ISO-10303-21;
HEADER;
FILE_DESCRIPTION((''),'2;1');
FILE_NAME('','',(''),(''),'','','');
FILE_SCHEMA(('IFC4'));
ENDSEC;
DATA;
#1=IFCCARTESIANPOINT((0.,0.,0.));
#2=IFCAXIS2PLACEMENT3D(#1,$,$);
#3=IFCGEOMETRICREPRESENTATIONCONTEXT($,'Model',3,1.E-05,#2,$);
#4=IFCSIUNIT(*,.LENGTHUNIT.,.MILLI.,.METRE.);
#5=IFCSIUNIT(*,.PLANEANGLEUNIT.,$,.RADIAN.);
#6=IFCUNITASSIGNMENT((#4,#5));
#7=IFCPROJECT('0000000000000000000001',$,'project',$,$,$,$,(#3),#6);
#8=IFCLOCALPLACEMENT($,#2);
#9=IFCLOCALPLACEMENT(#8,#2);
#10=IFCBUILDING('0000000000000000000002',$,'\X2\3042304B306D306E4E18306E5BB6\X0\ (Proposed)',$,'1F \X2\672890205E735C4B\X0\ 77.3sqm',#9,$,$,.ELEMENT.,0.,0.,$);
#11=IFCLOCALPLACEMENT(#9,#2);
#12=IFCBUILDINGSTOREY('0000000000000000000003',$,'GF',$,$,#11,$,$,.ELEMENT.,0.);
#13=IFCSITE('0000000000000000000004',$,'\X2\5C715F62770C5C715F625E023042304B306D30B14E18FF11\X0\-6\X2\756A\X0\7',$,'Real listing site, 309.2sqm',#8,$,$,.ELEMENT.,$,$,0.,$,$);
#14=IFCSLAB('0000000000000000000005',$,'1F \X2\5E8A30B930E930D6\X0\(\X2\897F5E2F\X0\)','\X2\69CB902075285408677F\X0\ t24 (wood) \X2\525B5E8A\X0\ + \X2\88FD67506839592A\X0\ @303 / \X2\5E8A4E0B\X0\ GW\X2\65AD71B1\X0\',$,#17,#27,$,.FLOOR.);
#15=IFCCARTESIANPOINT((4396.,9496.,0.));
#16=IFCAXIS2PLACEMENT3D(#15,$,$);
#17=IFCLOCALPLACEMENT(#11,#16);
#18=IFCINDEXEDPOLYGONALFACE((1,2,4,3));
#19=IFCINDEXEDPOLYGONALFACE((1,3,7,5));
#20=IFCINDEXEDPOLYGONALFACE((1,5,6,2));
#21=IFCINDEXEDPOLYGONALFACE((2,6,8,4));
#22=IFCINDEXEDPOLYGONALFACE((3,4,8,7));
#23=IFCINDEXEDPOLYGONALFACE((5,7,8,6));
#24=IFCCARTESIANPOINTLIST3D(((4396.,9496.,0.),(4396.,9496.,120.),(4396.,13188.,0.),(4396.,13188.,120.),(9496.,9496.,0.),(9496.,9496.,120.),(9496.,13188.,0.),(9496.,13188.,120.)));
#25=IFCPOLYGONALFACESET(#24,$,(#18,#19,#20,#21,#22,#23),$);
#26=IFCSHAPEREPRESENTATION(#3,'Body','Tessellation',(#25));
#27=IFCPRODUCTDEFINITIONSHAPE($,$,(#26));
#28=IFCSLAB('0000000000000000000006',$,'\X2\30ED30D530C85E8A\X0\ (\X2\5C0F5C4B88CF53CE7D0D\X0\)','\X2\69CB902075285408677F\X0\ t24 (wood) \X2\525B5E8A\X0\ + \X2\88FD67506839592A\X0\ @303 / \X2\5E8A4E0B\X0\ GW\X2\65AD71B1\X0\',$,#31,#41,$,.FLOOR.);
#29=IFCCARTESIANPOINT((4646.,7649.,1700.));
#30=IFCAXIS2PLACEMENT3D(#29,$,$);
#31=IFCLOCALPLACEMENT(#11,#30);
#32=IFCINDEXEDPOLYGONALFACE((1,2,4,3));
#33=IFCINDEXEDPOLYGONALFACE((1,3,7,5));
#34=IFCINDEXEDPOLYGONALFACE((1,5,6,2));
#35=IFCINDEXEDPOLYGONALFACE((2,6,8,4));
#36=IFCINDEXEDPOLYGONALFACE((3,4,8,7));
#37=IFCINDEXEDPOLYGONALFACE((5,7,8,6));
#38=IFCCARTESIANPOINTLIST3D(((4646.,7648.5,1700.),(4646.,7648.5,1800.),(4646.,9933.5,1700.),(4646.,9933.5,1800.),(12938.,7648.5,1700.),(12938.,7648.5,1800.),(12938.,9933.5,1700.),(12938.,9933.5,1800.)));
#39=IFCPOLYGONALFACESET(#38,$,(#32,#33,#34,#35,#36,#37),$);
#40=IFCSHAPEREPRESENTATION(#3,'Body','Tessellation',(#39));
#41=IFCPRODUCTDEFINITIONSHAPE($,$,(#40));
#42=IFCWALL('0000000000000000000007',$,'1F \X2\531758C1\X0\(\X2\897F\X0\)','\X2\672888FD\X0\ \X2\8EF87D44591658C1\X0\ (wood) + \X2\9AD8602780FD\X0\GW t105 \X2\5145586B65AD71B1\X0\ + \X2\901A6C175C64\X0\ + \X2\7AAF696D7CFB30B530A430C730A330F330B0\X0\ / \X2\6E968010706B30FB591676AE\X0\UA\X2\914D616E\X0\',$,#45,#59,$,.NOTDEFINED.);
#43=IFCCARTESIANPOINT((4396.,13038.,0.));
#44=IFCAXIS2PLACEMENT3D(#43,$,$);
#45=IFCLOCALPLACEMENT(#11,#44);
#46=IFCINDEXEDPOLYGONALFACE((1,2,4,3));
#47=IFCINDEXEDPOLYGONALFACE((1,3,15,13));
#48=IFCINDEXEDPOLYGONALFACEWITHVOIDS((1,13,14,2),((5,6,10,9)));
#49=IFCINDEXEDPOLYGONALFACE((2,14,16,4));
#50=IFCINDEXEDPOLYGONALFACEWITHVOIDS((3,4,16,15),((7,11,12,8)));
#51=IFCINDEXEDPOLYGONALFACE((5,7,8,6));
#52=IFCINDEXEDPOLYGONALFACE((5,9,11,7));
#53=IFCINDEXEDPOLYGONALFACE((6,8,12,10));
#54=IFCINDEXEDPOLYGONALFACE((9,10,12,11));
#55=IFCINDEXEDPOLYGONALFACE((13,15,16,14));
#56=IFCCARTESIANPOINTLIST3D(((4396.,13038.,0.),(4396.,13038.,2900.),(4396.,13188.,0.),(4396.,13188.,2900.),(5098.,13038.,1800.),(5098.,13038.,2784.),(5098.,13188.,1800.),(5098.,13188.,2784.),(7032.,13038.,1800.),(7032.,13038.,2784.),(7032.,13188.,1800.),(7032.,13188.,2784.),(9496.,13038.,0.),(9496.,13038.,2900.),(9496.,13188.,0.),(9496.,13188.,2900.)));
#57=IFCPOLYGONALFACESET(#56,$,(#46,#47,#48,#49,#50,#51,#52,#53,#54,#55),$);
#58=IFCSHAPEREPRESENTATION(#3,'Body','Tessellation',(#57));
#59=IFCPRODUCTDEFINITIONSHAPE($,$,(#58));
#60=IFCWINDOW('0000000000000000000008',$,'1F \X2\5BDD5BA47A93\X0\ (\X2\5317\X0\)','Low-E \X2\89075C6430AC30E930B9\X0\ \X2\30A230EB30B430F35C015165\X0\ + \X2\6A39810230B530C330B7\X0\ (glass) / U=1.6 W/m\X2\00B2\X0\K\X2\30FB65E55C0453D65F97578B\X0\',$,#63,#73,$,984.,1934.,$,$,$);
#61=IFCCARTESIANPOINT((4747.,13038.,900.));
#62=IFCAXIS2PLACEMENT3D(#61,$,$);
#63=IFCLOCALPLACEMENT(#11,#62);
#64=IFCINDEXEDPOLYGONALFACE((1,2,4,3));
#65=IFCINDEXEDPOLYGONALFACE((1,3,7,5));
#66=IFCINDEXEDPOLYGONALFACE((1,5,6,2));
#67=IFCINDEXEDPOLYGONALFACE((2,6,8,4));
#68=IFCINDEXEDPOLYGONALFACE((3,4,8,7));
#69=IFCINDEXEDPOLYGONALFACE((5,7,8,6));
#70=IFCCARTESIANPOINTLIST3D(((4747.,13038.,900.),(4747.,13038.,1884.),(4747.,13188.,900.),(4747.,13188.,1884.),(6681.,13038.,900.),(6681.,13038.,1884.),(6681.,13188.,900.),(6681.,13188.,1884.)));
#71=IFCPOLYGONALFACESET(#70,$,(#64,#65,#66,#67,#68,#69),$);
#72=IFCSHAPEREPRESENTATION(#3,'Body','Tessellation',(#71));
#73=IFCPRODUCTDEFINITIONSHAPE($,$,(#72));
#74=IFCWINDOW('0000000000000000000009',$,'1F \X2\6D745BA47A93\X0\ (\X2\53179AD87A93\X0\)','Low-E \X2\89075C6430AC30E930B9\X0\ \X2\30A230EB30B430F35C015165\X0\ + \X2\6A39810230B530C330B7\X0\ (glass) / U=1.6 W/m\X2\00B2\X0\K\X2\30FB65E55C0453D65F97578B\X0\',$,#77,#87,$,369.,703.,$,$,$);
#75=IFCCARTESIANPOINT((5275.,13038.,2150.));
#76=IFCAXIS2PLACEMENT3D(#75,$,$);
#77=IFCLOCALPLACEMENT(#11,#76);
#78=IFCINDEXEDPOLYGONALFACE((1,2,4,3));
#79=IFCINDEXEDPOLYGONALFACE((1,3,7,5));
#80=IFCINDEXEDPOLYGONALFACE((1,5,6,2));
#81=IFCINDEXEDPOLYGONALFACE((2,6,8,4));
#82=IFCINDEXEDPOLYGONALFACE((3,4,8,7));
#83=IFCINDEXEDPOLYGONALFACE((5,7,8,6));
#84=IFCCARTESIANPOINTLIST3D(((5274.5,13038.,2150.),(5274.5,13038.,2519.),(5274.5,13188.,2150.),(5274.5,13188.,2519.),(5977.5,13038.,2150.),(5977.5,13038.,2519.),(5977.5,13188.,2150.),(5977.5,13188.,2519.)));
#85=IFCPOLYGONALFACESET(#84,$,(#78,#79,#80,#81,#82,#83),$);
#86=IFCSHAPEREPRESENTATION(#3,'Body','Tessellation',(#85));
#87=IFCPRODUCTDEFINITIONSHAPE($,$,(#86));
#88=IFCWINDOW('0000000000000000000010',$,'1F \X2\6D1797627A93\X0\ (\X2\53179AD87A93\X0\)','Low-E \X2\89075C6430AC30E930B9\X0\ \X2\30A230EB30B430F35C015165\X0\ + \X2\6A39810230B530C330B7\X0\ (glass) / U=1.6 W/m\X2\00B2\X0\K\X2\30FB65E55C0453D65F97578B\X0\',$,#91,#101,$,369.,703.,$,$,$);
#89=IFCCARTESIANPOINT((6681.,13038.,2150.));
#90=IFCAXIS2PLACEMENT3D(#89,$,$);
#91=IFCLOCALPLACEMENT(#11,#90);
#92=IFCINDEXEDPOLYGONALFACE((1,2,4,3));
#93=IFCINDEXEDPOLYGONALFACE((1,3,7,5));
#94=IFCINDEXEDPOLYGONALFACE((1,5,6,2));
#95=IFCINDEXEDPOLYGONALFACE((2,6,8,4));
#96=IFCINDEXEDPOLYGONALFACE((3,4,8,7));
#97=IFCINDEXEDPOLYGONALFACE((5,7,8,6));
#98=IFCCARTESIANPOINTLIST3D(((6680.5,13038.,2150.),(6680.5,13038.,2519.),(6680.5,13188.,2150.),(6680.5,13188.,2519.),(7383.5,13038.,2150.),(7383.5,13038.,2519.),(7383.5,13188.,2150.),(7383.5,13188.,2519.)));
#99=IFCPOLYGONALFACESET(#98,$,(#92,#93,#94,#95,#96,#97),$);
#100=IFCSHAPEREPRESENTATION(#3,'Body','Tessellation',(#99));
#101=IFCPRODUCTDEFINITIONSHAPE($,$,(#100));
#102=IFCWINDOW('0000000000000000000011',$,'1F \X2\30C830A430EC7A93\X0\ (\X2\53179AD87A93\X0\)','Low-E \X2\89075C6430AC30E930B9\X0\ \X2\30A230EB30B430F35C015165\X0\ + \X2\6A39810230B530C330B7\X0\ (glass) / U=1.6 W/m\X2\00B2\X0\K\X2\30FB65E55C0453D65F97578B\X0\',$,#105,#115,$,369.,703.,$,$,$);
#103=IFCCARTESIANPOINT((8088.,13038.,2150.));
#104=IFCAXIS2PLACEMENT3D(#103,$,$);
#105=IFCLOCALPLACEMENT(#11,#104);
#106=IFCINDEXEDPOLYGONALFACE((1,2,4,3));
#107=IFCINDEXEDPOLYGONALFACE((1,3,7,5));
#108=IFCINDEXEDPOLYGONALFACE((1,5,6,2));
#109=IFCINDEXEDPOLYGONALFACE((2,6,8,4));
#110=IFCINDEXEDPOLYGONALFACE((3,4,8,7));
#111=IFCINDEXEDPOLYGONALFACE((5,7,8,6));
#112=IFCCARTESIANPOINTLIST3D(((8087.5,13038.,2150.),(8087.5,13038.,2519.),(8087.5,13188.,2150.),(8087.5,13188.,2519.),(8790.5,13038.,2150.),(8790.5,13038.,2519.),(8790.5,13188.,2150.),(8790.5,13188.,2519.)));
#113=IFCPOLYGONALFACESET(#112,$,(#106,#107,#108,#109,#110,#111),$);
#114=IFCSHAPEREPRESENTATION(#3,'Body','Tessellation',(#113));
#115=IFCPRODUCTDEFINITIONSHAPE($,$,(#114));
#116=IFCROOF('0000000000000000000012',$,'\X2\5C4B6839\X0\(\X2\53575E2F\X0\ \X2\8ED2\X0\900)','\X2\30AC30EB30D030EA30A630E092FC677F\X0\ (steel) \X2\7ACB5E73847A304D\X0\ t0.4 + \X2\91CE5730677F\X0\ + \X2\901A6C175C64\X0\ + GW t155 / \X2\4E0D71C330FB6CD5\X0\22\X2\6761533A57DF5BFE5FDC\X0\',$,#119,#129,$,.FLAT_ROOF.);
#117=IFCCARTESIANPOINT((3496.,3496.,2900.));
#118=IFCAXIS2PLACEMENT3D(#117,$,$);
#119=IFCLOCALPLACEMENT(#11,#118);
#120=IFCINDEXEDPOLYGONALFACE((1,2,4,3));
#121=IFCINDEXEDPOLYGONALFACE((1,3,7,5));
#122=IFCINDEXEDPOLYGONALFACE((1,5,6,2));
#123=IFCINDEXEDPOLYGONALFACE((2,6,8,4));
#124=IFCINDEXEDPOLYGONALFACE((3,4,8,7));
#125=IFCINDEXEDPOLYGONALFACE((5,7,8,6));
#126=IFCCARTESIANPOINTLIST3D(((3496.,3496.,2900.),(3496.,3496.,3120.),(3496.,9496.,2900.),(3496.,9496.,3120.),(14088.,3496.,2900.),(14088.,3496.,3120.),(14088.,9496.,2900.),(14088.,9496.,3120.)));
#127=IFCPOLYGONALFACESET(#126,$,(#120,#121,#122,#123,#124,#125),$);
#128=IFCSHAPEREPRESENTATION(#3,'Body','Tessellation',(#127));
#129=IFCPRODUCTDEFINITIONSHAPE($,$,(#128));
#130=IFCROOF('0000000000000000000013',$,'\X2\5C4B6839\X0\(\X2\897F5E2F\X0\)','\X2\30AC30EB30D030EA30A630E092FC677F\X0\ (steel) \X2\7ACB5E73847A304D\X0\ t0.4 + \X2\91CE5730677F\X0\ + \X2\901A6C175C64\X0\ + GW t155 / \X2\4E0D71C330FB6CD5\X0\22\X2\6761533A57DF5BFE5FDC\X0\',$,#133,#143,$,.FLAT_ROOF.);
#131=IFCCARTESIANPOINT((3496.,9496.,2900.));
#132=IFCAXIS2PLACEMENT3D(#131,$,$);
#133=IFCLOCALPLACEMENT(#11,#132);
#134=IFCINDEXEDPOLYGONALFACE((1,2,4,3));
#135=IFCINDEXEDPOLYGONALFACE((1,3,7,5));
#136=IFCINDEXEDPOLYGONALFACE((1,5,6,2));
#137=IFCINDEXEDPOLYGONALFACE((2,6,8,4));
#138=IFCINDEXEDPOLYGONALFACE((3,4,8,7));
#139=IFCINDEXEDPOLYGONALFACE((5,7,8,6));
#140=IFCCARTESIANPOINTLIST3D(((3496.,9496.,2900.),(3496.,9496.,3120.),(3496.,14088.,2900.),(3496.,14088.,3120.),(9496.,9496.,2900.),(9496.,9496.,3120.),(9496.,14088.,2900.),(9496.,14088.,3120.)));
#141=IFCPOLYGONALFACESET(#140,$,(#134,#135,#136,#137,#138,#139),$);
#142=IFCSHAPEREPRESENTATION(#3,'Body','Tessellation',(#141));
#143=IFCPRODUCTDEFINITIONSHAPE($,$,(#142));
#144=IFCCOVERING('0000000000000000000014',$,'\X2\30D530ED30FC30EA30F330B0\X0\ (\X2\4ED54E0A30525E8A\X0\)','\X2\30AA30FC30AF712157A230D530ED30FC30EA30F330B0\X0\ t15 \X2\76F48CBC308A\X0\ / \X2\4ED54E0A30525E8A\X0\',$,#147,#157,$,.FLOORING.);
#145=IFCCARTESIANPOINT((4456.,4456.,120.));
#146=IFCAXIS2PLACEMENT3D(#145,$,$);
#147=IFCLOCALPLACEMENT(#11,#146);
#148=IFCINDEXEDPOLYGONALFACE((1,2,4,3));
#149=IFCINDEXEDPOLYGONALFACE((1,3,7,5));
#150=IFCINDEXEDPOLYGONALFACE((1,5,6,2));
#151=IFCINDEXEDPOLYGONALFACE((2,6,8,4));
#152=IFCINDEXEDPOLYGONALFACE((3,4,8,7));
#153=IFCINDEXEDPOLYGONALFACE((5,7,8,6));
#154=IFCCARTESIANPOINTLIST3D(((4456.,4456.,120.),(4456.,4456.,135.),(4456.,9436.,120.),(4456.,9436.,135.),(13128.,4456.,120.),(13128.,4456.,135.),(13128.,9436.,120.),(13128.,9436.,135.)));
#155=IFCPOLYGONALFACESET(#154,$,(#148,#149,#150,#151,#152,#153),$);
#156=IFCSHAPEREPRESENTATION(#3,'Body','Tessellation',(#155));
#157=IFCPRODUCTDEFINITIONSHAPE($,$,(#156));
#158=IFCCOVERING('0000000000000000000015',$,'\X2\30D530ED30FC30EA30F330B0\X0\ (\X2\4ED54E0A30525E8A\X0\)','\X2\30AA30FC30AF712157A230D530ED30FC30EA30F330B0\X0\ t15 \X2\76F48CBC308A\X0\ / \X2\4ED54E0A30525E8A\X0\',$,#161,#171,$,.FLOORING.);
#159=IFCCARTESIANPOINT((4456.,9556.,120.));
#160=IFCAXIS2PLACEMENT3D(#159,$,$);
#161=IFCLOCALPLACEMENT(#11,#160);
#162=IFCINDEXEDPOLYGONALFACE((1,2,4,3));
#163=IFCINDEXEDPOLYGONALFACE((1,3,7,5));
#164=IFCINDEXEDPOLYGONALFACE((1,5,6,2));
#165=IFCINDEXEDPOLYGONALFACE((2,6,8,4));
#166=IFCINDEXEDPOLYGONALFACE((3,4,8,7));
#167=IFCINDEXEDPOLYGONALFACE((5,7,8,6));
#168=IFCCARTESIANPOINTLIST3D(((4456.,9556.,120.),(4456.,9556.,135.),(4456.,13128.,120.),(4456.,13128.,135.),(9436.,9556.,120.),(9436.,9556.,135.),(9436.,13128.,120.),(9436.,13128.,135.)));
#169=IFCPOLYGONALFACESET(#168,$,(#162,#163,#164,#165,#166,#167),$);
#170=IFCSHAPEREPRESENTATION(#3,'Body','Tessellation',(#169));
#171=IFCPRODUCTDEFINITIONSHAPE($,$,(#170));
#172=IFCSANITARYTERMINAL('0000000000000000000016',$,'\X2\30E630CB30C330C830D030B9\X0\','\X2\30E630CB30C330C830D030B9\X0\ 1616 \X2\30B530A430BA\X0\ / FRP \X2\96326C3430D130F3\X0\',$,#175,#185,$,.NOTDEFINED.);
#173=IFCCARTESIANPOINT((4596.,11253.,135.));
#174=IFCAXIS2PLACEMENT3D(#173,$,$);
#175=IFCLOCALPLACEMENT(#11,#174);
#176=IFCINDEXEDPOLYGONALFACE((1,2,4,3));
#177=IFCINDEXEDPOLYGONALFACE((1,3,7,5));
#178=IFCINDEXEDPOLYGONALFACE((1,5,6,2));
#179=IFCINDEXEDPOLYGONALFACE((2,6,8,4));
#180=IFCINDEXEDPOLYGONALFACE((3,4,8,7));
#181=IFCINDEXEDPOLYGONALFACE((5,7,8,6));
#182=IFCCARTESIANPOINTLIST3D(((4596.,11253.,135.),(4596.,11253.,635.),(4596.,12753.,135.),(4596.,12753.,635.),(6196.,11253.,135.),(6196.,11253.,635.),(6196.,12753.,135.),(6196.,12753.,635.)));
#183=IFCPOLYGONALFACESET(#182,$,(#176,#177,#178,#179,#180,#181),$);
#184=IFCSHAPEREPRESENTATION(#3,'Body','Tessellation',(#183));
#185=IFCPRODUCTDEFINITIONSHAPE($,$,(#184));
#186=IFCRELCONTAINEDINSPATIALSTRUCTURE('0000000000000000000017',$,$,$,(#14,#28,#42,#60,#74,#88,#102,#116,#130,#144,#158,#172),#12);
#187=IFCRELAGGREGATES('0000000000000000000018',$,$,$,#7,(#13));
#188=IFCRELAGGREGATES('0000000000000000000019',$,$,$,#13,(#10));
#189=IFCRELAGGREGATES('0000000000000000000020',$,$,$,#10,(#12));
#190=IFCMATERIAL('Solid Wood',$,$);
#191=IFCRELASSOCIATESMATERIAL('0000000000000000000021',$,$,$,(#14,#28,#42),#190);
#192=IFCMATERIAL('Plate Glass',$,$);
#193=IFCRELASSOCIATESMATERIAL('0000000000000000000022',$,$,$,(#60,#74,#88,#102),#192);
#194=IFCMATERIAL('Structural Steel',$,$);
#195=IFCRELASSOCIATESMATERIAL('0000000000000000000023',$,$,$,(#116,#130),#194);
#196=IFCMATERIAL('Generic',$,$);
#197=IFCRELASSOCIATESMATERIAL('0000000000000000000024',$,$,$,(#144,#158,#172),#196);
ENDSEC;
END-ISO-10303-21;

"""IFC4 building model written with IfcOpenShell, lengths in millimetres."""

from ifc_helpers import new_model, si_unit, frame, frame_2d, origin, place, context, project, spatial, rectangle, extrude, material, element, fill, save


model = new_model("IFC4")

# Units and contexts
model_context = context("Model", 3, precision=1e-05, world=origin())
ifc_project = project(units=[si_unit("LENGTHUNIT", "METRE", prefix="MILLI"), si_unit("PLANEANGLEUNIT", "RADIAN")], contexts=[model_context])

# Site, building, storey
site_placement = place(None, origin())
site = spatial("IfcSite", under=ifc_project, at=site_placement, Name="山形県山形市あかねケ丘１-6番7", ObjectType="Real listing site, 309.2sqm", CompositionType="ELEMENT", RefElevation=0.0)
building_placement = place(site_placement, origin())
building = spatial("IfcBuilding", under=site, at=building_placement, Name="あかねの丘の家 (Proposed)", ObjectType="1F 木造平屋 77.3sqm", CompositionType="ELEMENT", ElevationOfRefHeight=0.0, ElevationOfTerrain=0.0)
storey_placement = place(building_placement, origin())
storey = spatial("IfcBuildingStorey", under=building, at=storey_placement, Name="GF", CompositionType="ELEMENT", Elevation=0.0)

# Slabs
ifc_material_1 = material(Name="Solid Wood")
slab_1_placement = place(storey_placement, frame((4396.0, 9496.0, 0.0)))
element("IfcSlab", 1, at=slab_1_placement, inside=storey, material=ifc_material_1, Name="1F 床スラブ(西帯)", Description="構造用合板 t24 (wood) 剛床 + 製材根太 @303 / 床下 GW断熱", PredefinedType="FLOOR", context=model_context, shape_type="SweptSolid", body=[
    extrude(rectangle(XDim=5100.0, YDim=3692.0, at=frame_2d((2550.0, 1846.0))), frame((4396.0, 9496.0, 0.0)), (0.0, 0.0, 1.0), 120.0),
])
slab_2_placement = place(storey_placement, frame((4646.0, 7649.0, 1700.0)))
element("IfcSlab", 2, at=slab_2_placement, inside=storey, material=ifc_material_1, Name="ロフト床 (小屋裏収納)", Description="構造用合板 t24 (wood) 剛床 + 製材根太 @303 / 床下 GW断熱", PredefinedType="FLOOR", context=model_context, shape_type="SweptSolid", body=[
    extrude(rectangle(XDim=8292.0, YDim=2285.0, at=frame_2d((4146.0, 1142.0))), frame((4646.0, 7649.0, 1700.0)), (0.0, 0.0, 1.0), 100.0),
])

# Shared definitions
ifc_material_2 = material(Name="Plate Glass")

# Wall, openings, windows
wall_1_placement = place(storey_placement, frame((4396.0, 13038.0, 0.0)))
wall_1 = element("IfcWall", 3, at=wall_1_placement, inside=storey, material=ifc_material_1, Name="1F 北壁(西)", Description="木製 軸組外壁 (wood) + 高性能GW t105 充填断熱 + 通気層 + 窯業系サイディング / 準耐火・外皮UA配慮", PredefinedType="NOTDEFINED", context=model_context, shape_type="SweptSolid", body=[
    extrude(rectangle(XDim=5100.0, YDim=150.0, at=frame_2d((2550.0, 75.0))), frame((4396.0, 13038.0, 0.0)), (0.0, 0.0, 1.0), 2900.0),
])
opening_1_placement = place(storey_placement, frame((4747.0, 13038.0, 900.0)))
opening_1 = element("IfcOpeningElement", 4, at=opening_1_placement, cuts=wall_1, PredefinedType="NOTDEFINED", context=model_context, shape_type="SweptSolid", body=[
    extrude(rectangle(XDim=1934.0, YDim=150.0, at=frame_2d((967.0, 75.0))), frame((4747.0, 13038.0, 900.0)), (0.0, 0.0, 1.0), 984.0),
])
opening_2_placement = place(storey_placement, frame((5275.0, 13038.0, 2150.0)))
opening_2 = element("IfcOpeningElement", 5, at=opening_2_placement, cuts=wall_1, PredefinedType="NOTDEFINED", context=model_context, shape_type="SweptSolid", body=[
    extrude(rectangle(XDim=703.0, YDim=150.0, at=frame_2d((351.0, 75.0))), frame((5275.0, 13038.0, 2150.0)), (0.0, 0.0, 1.0), 369.0),
])
opening_3_placement = place(storey_placement, frame((6681.0, 13038.0, 2150.0)))
opening_3 = element("IfcOpeningElement", 6, at=opening_3_placement, cuts=wall_1, PredefinedType="NOTDEFINED", context=model_context, shape_type="SweptSolid", body=[
    extrude(rectangle(XDim=703.0, YDim=150.0, at=frame_2d((351.0, 75.0))), frame((6681.0, 13038.0, 2150.0)), (0.0, 0.0, 1.0), 369.0),
])
opening_4_placement = place(storey_placement, frame((8088.0, 13038.0, 2150.0)))
opening_4 = element("IfcOpeningElement", 7, at=opening_4_placement, cuts=wall_1, PredefinedType="NOTDEFINED", context=model_context, shape_type="SweptSolid", body=[
    extrude(rectangle(XDim=703.0, YDim=150.0, at=frame_2d((351.0, 75.0))), frame((8088.0, 13038.0, 2150.0)), (0.0, 0.0, 1.0), 369.0),
])
window_1_placement = place(storey_placement, frame((4747.0, 13038.0, 900.0)))
window_1 = element("IfcWindow", 8, at=window_1_placement, inside=storey, material=ifc_material_2, Name="1F 寝室窓 (北)", Description="Low-E 複層ガラス アルゴン封入 + 樹脂サッシ (glass) / U=1.6 W/m²K・日射取得型", OverallHeight=984.0, OverallWidth=1934.0, context=model_context, shape_type="SweptSolid", body=[
    extrude(rectangle(XDim=1934.0, YDim=150.0, at=frame_2d((967.0, 75.0))), frame((4747.0, 13038.0, 900.0)), (0.0, 0.0, 1.0), 984.0),
])
fill(opening_1, window_1)
window_2_placement = place(storey_placement, frame((5275.0, 13038.0, 2150.0)))
window_2 = element("IfcWindow", 9, at=window_2_placement, inside=storey, material=ifc_material_2, Name="1F 浴室窓 (北高窓)", Description="Low-E 複層ガラス アルゴン封入 + 樹脂サッシ (glass) / U=1.6 W/m²K・日射取得型", OverallHeight=369.0, OverallWidth=703.0, context=model_context, shape_type="SweptSolid", body=[
    extrude(rectangle(XDim=703.0, YDim=150.0, at=frame_2d((351.0, 75.0))), frame((5275.0, 13038.0, 2150.0)), (0.0, 0.0, 1.0), 369.0),
])
fill(opening_2, window_2)
window_3_placement = place(storey_placement, frame((6681.0, 13038.0, 2150.0)))
window_3 = element("IfcWindow", 10, at=window_3_placement, inside=storey, material=ifc_material_2, Name="1F 洗面窓 (北高窓)", Description="Low-E 複層ガラス アルゴン封入 + 樹脂サッシ (glass) / U=1.6 W/m²K・日射取得型", OverallHeight=369.0, OverallWidth=703.0, context=model_context, shape_type="SweptSolid", body=[
    extrude(rectangle(XDim=703.0, YDim=150.0, at=frame_2d((351.0, 75.0))), frame((6681.0, 13038.0, 2150.0)), (0.0, 0.0, 1.0), 369.0),
])
fill(opening_3, window_3)
window_4_placement = place(storey_placement, frame((8088.0, 13038.0, 2150.0)))
window_4 = element("IfcWindow", 11, at=window_4_placement, inside=storey, material=ifc_material_2, Name="1F トイレ窓 (北高窓)", Description="Low-E 複層ガラス アルゴン封入 + 樹脂サッシ (glass) / U=1.6 W/m²K・日射取得型", OverallHeight=369.0, OverallWidth=703.0, context=model_context, shape_type="SweptSolid", body=[
    extrude(rectangle(XDim=703.0, YDim=150.0, at=frame_2d((351.0, 75.0))), frame((8088.0, 13038.0, 2150.0)), (0.0, 0.0, 1.0), 369.0),
])
fill(opening_4, window_4)

# Roofs
ifc_material_3 = material(Name="Structural Steel")
roof_1_placement = place(storey_placement, frame((3496.0, 3496.0, 2900.0)))
element("IfcRoof", 12, at=roof_1_placement, inside=storey, material=ifc_material_3, Name="屋根(南帯 軒900)", Description="ガルバリウム鋼板 (steel) 立平葺き t0.4 + 野地板 + 通気層 + GW t155 / 不燃・法22条区域対応", PredefinedType="FLAT_ROOF", context=model_context, shape_type="SweptSolid", body=[
    extrude(rectangle(XDim=10592.0, YDim=6000.0, at=frame_2d((5296.0, 3000.0))), frame((3496.0, 3496.0, 2900.0)), (0.0, 0.0, 1.0), 220.0),
])
roof_2_placement = place(storey_placement, frame((3496.0, 9496.0, 2900.0)))
element("IfcRoof", 13, at=roof_2_placement, inside=storey, material=ifc_material_3, Name="屋根(西帯)", Description="ガルバリウム鋼板 (steel) 立平葺き t0.4 + 野地板 + 通気層 + GW t155 / 不燃・法22条区域対応", PredefinedType="FLAT_ROOF", context=model_context, shape_type="SweptSolid", body=[
    extrude(rectangle(XDim=6000.0, YDim=4592.0, at=frame_2d((3000.0, 2296.0))), frame((3496.0, 9496.0, 2900.0)), (0.0, 0.0, 1.0), 220.0),
])

# Coverings
ifc_material_4 = material(Name="Generic")
covering_1_placement = place(storey_placement, frame((4456.0, 4456.0, 120.0)))
element("IfcCovering", 14, at=covering_1_placement, inside=storey, material=ifc_material_4, Name="フローリング (仕上げ床)", Description="オーク無垢フローリング t15 直貼り / 仕上げ床", PredefinedType="FLOORING", context=model_context, shape_type="SweptSolid", body=[
    extrude(rectangle(XDim=8672.0, YDim=4980.0, at=frame_2d((4336.0, 2490.0))), frame((4456.0, 4456.0, 120.0)), (0.0, 0.0, 1.0), 15.0),
])
covering_2_placement = place(storey_placement, frame((4456.0, 9556.0, 120.0)))
element("IfcCovering", 15, at=covering_2_placement, inside=storey, material=ifc_material_4, Name="フローリング (仕上げ床)", Description="オーク無垢フローリング t15 直貼り / 仕上げ床", PredefinedType="FLOORING", context=model_context, shape_type="SweptSolid", body=[
    extrude(rectangle(XDim=4980.0, YDim=3572.0, at=frame_2d((2490.0, 1786.0))), frame((4456.0, 9556.0, 120.0)), (0.0, 0.0, 1.0), 15.0),
])

# Sanitary terminal
sanitary_terminal_placement = place(storey_placement, frame((4596.0, 11253.0, 135.0)))
element("IfcSanitaryTerminal", 16, at=sanitary_terminal_placement, inside=storey, material=ifc_material_4, Name="ユニットバス", Description="ユニットバス 1616 サイズ / FRP 防水パン", PredefinedType="NOTDEFINED", context=model_context, shape_type="SweptSolid", body=[
    extrude(rectangle(XDim=1600.0, YDim=1500.0, at=frame_2d((800.0, 750.0))), frame((4596.0, 11253.0, 135.0)), (0.0, 0.0, 1.0), 500.0),
])

save(model, "model.ifc")
